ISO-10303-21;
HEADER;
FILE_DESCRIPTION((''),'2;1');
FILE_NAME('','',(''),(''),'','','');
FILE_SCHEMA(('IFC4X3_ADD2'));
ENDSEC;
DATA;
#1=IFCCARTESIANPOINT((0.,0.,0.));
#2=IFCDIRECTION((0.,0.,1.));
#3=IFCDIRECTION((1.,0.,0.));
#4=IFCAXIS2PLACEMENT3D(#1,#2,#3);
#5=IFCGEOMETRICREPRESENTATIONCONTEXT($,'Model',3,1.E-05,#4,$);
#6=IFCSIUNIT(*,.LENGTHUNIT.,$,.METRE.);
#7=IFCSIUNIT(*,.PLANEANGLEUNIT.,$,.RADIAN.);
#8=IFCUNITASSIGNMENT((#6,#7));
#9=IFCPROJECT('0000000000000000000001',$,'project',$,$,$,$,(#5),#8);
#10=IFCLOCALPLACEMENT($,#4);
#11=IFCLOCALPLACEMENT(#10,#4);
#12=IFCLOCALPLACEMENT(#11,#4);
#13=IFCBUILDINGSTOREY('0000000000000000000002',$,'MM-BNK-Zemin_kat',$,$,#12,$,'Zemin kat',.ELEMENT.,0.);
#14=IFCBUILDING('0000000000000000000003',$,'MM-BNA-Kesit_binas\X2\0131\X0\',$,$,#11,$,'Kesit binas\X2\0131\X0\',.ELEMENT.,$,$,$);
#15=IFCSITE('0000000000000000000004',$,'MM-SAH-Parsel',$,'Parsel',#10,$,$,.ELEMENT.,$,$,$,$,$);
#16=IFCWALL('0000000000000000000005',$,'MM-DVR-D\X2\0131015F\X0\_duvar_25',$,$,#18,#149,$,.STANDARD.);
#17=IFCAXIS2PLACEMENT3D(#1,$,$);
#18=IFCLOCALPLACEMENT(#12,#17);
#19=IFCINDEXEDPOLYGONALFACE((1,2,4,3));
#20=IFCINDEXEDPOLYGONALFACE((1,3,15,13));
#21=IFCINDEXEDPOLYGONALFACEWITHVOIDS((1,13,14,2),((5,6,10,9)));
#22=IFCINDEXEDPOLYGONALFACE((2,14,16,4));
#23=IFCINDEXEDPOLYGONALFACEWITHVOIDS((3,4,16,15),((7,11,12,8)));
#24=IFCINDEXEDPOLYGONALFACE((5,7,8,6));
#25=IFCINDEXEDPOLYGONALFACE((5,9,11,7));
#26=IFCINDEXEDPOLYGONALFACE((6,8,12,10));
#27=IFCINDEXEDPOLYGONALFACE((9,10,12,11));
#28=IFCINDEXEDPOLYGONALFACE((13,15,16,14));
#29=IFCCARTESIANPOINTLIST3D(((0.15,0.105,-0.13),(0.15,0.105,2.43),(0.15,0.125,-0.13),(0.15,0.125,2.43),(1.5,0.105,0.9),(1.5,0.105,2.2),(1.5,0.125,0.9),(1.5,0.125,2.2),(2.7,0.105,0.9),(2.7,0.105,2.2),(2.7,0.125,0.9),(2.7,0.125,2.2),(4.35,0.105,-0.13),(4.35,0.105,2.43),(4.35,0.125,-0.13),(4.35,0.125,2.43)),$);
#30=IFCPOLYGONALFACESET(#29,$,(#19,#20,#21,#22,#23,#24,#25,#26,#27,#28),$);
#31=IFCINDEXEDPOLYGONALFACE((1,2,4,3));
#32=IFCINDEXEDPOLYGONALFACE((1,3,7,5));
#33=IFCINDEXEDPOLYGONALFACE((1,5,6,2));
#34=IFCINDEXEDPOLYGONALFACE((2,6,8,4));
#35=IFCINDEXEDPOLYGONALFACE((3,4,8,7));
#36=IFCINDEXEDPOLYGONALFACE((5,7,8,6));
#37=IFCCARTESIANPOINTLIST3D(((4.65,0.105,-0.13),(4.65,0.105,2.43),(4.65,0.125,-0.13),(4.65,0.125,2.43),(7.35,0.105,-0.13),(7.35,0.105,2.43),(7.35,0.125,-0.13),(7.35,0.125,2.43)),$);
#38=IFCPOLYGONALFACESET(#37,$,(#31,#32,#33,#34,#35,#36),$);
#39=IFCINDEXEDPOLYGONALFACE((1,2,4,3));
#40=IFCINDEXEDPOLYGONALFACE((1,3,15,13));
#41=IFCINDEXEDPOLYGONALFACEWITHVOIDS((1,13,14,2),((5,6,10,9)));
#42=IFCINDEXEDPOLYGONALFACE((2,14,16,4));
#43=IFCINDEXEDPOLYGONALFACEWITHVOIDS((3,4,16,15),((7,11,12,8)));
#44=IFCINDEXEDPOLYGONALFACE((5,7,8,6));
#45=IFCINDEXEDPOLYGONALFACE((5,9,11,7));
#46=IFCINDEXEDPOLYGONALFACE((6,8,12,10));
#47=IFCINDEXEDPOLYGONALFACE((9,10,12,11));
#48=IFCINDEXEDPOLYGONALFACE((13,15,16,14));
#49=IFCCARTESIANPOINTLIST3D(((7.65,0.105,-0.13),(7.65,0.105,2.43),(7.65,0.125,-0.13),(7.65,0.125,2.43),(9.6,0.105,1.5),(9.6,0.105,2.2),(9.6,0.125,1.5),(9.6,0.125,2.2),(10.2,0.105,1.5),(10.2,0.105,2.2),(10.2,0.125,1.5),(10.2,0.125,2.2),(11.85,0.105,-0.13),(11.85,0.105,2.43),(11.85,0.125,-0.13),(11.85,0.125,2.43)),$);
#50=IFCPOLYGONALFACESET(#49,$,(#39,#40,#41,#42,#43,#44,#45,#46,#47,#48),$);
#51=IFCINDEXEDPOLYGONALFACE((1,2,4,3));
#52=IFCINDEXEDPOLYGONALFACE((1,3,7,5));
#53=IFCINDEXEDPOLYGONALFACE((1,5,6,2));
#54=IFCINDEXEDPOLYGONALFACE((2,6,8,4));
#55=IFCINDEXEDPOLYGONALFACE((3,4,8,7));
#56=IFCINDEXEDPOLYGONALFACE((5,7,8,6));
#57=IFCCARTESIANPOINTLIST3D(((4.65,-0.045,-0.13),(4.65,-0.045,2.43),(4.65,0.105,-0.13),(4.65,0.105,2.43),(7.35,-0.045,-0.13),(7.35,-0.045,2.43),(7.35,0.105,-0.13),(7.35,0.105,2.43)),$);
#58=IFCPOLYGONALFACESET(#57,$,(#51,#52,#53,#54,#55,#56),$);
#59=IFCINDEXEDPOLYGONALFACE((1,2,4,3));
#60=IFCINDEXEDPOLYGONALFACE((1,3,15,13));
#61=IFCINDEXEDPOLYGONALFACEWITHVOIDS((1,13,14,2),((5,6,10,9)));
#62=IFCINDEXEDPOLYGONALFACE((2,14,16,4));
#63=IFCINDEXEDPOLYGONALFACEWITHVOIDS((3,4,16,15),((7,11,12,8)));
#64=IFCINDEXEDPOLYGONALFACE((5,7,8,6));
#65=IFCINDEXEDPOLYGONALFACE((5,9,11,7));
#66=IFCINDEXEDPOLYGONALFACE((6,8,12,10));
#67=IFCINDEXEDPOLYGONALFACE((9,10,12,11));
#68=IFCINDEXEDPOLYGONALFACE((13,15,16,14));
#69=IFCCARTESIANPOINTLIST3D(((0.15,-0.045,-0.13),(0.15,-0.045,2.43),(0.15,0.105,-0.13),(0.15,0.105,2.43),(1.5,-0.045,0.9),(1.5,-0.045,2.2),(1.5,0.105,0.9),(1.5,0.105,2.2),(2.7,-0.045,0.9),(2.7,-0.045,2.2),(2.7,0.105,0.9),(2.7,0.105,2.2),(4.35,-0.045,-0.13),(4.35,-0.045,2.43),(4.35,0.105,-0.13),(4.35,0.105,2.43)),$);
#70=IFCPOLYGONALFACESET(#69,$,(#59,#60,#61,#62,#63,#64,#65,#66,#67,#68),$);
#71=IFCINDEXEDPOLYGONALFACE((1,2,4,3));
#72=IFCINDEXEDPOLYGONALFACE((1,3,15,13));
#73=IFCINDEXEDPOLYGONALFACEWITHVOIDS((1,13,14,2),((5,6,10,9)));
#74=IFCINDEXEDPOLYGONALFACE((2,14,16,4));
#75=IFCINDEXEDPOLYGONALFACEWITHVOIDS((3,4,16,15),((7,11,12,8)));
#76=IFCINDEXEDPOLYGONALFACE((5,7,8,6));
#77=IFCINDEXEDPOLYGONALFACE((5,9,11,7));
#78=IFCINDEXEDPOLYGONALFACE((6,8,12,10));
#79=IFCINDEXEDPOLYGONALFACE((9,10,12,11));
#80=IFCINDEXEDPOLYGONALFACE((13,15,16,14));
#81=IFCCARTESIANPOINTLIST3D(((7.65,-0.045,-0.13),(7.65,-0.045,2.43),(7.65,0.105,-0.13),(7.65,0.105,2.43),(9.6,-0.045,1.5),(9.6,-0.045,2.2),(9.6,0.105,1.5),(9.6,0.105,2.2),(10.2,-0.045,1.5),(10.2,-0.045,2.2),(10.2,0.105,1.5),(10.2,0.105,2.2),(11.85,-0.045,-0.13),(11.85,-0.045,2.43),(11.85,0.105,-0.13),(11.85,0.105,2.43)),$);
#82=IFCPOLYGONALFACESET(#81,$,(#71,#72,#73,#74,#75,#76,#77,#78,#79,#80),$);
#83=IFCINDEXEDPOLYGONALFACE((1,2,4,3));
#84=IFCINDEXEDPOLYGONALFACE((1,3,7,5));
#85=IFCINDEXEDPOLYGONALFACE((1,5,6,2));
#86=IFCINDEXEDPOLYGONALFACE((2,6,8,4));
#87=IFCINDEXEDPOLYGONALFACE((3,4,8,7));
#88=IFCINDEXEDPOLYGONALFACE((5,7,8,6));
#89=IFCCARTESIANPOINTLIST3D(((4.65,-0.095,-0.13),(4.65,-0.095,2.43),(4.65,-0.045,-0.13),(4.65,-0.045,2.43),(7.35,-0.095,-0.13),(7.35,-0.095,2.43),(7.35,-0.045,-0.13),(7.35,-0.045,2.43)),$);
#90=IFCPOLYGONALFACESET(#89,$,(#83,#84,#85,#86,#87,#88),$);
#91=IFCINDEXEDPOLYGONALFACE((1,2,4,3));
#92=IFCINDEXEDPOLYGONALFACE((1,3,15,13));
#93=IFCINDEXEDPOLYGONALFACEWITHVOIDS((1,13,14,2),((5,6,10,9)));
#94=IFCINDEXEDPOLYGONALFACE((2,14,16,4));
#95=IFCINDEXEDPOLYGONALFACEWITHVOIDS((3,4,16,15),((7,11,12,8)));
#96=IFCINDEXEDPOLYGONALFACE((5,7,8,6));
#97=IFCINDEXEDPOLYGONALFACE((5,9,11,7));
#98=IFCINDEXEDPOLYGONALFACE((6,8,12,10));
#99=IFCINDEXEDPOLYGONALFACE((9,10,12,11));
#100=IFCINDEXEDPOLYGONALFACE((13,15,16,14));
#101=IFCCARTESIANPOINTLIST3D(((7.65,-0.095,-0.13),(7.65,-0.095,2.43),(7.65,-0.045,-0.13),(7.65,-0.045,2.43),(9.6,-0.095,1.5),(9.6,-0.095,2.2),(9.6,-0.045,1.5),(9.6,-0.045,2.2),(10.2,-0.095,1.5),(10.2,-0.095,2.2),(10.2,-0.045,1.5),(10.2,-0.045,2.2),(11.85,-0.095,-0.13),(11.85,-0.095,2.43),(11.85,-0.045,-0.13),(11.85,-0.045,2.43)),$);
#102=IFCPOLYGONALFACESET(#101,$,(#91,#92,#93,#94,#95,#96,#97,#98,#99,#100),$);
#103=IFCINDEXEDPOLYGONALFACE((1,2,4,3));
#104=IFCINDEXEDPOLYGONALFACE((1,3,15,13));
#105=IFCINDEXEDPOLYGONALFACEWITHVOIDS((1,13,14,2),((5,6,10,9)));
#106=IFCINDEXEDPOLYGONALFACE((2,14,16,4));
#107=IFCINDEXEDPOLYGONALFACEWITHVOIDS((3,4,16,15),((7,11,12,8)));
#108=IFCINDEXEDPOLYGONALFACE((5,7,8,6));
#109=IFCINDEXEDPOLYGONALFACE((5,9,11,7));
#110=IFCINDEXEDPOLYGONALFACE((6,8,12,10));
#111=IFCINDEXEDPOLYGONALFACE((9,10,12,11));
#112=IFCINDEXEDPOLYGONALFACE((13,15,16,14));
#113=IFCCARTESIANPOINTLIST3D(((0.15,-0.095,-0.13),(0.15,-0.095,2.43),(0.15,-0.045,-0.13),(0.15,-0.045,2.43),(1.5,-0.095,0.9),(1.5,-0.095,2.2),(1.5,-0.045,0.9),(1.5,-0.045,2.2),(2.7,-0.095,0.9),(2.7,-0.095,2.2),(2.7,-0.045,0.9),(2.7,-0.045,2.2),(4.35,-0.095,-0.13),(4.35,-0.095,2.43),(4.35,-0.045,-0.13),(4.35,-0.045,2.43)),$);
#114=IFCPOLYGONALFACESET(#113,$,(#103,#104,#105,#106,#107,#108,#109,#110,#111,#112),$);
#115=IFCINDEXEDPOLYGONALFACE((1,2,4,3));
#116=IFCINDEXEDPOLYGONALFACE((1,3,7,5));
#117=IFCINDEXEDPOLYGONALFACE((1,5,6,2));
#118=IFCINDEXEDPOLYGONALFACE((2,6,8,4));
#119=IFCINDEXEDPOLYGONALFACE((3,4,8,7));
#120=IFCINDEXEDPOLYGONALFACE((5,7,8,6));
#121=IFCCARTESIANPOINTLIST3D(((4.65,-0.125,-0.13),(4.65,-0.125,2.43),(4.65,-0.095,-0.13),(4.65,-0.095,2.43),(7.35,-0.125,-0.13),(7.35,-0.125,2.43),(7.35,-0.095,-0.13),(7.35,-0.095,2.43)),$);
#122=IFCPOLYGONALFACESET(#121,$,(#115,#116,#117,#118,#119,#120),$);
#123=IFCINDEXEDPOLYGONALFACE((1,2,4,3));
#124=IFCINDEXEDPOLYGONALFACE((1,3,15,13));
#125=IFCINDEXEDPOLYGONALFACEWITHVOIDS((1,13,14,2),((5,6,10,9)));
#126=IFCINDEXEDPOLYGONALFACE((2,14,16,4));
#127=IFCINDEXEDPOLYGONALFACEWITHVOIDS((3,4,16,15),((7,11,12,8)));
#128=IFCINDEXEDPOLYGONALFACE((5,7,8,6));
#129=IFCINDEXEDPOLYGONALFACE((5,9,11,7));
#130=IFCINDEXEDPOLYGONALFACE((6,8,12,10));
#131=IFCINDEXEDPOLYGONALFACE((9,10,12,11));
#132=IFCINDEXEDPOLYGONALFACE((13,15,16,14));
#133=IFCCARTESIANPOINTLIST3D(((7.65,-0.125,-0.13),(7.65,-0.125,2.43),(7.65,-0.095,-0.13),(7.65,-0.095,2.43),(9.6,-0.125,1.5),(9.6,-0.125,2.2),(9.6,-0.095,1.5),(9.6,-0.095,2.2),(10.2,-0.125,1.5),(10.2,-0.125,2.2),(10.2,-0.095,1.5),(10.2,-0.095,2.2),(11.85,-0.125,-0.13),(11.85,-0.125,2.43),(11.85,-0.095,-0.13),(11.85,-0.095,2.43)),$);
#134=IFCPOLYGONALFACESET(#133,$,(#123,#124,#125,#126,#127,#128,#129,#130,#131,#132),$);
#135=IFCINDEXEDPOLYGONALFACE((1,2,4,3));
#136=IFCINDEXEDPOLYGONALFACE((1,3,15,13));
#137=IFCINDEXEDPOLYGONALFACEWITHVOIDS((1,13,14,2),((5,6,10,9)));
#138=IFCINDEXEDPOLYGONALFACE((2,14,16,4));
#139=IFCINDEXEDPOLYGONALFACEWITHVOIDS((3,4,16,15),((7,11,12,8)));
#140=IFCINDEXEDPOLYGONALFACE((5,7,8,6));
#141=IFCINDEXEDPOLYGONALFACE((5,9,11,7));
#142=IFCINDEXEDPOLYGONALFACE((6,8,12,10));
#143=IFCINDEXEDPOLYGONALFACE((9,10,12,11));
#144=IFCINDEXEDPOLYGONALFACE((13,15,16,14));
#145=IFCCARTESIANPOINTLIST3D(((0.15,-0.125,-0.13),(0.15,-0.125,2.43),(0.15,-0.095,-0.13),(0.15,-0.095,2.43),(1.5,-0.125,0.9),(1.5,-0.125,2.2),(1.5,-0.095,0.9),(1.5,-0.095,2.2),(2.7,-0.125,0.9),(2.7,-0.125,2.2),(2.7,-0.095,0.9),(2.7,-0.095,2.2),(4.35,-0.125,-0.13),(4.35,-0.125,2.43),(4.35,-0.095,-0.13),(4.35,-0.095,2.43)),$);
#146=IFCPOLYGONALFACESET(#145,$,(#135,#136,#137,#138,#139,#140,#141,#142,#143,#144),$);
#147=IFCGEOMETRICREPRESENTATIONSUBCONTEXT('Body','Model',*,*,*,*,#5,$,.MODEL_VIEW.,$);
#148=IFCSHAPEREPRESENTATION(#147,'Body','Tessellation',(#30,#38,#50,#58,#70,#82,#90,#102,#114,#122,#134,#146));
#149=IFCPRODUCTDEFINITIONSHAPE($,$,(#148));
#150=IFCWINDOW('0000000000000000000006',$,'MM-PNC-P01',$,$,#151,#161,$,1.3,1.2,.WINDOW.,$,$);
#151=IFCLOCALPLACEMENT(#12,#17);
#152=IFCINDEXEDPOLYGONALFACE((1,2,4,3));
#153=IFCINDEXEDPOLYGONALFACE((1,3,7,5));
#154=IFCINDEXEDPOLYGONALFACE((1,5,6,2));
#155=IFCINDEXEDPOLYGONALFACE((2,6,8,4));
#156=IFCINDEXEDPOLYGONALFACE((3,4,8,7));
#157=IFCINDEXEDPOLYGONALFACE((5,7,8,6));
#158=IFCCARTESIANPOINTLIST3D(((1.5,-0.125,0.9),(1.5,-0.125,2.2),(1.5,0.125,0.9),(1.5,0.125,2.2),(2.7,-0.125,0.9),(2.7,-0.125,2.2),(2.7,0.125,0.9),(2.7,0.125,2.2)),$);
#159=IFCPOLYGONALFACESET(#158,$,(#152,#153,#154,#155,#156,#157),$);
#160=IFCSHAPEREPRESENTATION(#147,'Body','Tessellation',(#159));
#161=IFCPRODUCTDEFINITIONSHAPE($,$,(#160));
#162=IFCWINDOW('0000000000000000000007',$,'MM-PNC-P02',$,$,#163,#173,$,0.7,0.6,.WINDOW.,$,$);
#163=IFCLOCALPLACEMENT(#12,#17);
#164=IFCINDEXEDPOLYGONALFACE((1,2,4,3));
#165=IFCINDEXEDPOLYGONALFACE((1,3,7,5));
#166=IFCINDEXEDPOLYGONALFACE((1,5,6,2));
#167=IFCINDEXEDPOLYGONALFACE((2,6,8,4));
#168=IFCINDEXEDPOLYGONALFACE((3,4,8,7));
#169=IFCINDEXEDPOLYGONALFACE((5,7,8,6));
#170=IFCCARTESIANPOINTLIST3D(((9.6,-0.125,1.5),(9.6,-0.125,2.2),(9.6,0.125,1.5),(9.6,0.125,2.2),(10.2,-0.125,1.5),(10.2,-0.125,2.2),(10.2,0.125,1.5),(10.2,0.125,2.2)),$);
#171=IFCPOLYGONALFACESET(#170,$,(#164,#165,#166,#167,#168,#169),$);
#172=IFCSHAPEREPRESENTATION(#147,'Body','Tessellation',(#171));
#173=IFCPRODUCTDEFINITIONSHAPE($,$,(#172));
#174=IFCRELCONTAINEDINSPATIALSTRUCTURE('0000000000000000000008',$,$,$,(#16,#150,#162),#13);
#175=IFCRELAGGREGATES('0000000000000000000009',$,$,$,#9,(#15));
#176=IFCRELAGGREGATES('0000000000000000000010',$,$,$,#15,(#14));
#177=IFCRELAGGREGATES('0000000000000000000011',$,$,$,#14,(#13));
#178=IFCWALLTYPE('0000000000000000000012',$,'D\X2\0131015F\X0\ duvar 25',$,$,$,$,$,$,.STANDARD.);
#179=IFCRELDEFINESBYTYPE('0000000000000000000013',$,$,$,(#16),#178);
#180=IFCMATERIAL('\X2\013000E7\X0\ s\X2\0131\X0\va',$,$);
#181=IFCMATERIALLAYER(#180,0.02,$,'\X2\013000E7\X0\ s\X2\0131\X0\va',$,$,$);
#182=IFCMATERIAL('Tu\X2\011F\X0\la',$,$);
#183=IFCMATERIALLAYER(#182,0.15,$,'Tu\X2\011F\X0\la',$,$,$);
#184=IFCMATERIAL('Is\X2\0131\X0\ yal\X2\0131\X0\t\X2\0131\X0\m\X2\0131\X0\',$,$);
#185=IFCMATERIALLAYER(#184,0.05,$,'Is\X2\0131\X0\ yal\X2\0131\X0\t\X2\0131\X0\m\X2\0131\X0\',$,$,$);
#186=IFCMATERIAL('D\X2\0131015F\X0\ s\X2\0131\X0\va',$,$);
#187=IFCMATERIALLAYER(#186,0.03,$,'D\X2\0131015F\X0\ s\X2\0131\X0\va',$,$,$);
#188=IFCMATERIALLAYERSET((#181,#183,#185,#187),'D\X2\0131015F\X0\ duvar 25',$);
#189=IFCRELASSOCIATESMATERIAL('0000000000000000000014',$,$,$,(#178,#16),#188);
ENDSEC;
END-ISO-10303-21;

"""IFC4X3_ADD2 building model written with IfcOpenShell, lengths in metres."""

from ifc_helpers import new_model, si_unit, frame, origin_with_axes, place, context, subcontext, project, spatial, polyline, outline, extrude, material, layer, layer_set, type_object, element, fill, save


model = new_model("IFC4X3_ADD2")

# Units and contexts
model_context = context("Model", 3, precision=1e-05, world=origin_with_axes())
body_context = subcontext(model_context, "Body", "Model", "MODEL_VIEW")
ifc_project = project(units=[si_unit("LENGTHUNIT", "METRE"), si_unit("PLANEANGLEUNIT", "RADIAN")], contexts=[model_context])

# Site, building, storey
site_placement = place(None, origin_with_axes())
site = spatial("IfcSite", under=ifc_project, at=site_placement, Name="MM-SAH-Parsel", ObjectType="Parsel", CompositionType="ELEMENT")
building_placement = place(site_placement, origin_with_axes())
building = spatial("IfcBuilding", under=site, at=building_placement, Name="MM-BNA-Kesit_binası", LongName="Kesit binası", CompositionType="ELEMENT")
storey_placement = place(building_placement, origin_with_axes())
storey = spatial("IfcBuildingStorey", under=building, at=storey_placement, Name="MM-BNK-Zemin_kat", LongName="Zemin kat", CompositionType="ELEMENT", Elevation=0.0)

# Wall, openings, windows
ifc_material_1 = material(Name="İç sıva")
ifc_layer_1 = layer(ifc_material_1, 0.02, Name="İç sıva")
ifc_material_2 = material(Name="Tuğla")
ifc_layer_2 = layer(ifc_material_2, 0.15, Name="Tuğla")
ifc_material_3 = material(Name="Isı yalıtımı")
ifc_layer_3 = layer(ifc_material_3, 0.05, Name="Isı yalıtımı")
ifc_material_4 = material(Name="Dış sıva")
ifc_layer_4 = layer(ifc_material_4, 0.03, Name="Dış sıva")
ifc_layer_set_1 = layer_set([ifc_layer_1, ifc_layer_2, ifc_layer_3, ifc_layer_4], Name="Dış duvar 25")
wall_type_1 = type_object("IfcWallType", Name="Dış duvar 25", PredefinedType="STANDARD", material=ifc_layer_set_1)
wall_1_placement = place(storey_placement, origin_with_axes())
wall_1 = element("IfcWall", 1, at=wall_1_placement, inside=storey, type_object=wall_type_1, material=ifc_layer_set_1, Name="MM-DVR-Dış_duvar_25", PredefinedType="STANDARD", context=body_context, shape_type="SweptSolid", body=[
    extrude(outline(polyline([(0.15, 0.105), (4.35, 0.105), (4.35, 0.125), (0.15, 0.125), (0.15, 0.105)])), frame((0.0, 0.0, -0.13)), (0.0, 0.0, 1.0), 2.56),
    extrude(outline(polyline([(4.65, 0.105), (7.35, 0.105), (7.35, 0.125), (4.65, 0.125), (4.65, 0.105)])), frame((0.0, 0.0, -0.13)), (0.0, 0.0, 1.0), 2.56),
    extrude(outline(polyline([(7.65, 0.105), (11.85, 0.105), (11.85, 0.125), (7.65, 0.125), (7.65, 0.105)])), frame((0.0, 0.0, -0.13)), (0.0, 0.0, 1.0), 2.56),
    extrude(outline(polyline([(4.65, -0.045), (7.35, -0.045), (7.35, 0.105), (4.65, 0.105), (4.65, -0.045)])), frame((0.0, 0.0, -0.13)), (0.0, 0.0, 1.0), 2.56),
    extrude(outline(polyline([(0.15, -0.045), (4.35, -0.045), (4.35, 0.105), (0.15, 0.105), (0.15, -0.045)])), frame((0.0, 0.0, -0.13)), (0.0, 0.0, 1.0), 2.56),
    extrude(outline(polyline([(7.65, -0.045), (11.85, -0.045), (11.85, 0.105), (7.65, 0.105), (7.65, -0.045)])), frame((0.0, 0.0, -0.13)), (0.0, 0.0, 1.0), 2.56),
    extrude(outline(polyline([(4.65, -0.095), (7.35, -0.095), (7.35, -0.045), (4.65, -0.045), (4.65, -0.095)])), frame((0.0, 0.0, -0.13)), (0.0, 0.0, 1.0), 2.56),
    extrude(outline(polyline([(7.65, -0.095), (11.85, -0.095), (11.85, -0.045), (7.65, -0.045), (7.65, -0.095)])), frame((0.0, 0.0, -0.13)), (0.0, 0.0, 1.0), 2.56),
    extrude(outline(polyline([(0.15, -0.095), (4.35, -0.095), (4.35, -0.045), (0.15, -0.045), (0.15, -0.095)])), frame((0.0, 0.0, -0.13)), (0.0, 0.0, 1.0), 2.56),
    extrude(outline(polyline([(4.65, -0.125), (7.35, -0.125), (7.35, -0.095), (4.65, -0.095), (4.65, -0.125)])), frame((0.0, 0.0, -0.13)), (0.0, 0.0, 1.0), 2.56),
    extrude(outline(polyline([(7.65, -0.125), (11.85, -0.125), (11.85, -0.095), (7.65, -0.095), (7.65, -0.125)])), frame((0.0, 0.0, -0.13)), (0.0, 0.0, 1.0), 2.56),
    extrude(outline(polyline([(0.15, -0.125), (4.35, -0.125), (4.35, -0.095), (0.15, -0.095), (0.15, -0.125)])), frame((0.0, 0.0, -0.13)), (0.0, 0.0, 1.0), 2.56),
])
opening_1_placement = place(storey_placement, origin_with_axes())
opening_1 = element("IfcOpeningElement", 2, at=opening_1_placement, cuts=wall_1, PredefinedType="OPENING", context=body_context, shape_type="SweptSolid", body=[
    extrude(outline(polyline([(1.5, 0.125), (2.7, 0.125), (2.7, -0.125), (1.5, -0.125), (1.5, 0.125)])), frame((0.0, 0.0, 0.9)), (0.0, 0.0, 1.0), 1.3),
])
opening_2_placement = place(storey_placement, origin_with_axes())
opening_2 = element("IfcOpeningElement", 3, at=opening_2_placement, cuts=wall_1, PredefinedType="OPENING", context=body_context, shape_type="SweptSolid", body=[
    extrude(outline(polyline([(9.6, 0.125), (10.2, 0.125), (10.2, -0.125), (9.6, -0.125), (9.6, 0.125)])), frame((0.0, 0.0, 1.5)), (0.0, 0.0, 1.0), 0.7),
])
window_1_placement = place(storey_placement, origin_with_axes())
window_1 = element("IfcWindow", 4, at=window_1_placement, inside=storey, Name="MM-PNC-P01", OverallHeight=1.3, OverallWidth=1.2, PredefinedType="WINDOW", context=body_context, shape_type="SweptSolid", body=[
    extrude(outline(polyline([(1.5, 0.125), (2.7, 0.125), (2.7, -0.125), (1.5, -0.125), (1.5, 0.125)])), frame((0.0, 0.0, 0.9)), (0.0, 0.0, 1.0), 1.3),
])
fill(opening_1, window_1)
window_2_placement = place(storey_placement, origin_with_axes())
window_2 = element("IfcWindow", 5, at=window_2_placement, inside=storey, Name="MM-PNC-P02", OverallHeight=0.7, OverallWidth=0.6, PredefinedType="WINDOW", context=body_context, shape_type="SweptSolid", body=[
    extrude(outline(polyline([(9.6, 0.125), (10.2, 0.125), (10.2, -0.125), (9.6, -0.125), (9.6, 0.125)])), frame((0.0, 0.0, 1.5)), (0.0, 0.0, 1.0), 0.7),
])
fill(opening_2, window_2)

save(model, "model.ifc")
